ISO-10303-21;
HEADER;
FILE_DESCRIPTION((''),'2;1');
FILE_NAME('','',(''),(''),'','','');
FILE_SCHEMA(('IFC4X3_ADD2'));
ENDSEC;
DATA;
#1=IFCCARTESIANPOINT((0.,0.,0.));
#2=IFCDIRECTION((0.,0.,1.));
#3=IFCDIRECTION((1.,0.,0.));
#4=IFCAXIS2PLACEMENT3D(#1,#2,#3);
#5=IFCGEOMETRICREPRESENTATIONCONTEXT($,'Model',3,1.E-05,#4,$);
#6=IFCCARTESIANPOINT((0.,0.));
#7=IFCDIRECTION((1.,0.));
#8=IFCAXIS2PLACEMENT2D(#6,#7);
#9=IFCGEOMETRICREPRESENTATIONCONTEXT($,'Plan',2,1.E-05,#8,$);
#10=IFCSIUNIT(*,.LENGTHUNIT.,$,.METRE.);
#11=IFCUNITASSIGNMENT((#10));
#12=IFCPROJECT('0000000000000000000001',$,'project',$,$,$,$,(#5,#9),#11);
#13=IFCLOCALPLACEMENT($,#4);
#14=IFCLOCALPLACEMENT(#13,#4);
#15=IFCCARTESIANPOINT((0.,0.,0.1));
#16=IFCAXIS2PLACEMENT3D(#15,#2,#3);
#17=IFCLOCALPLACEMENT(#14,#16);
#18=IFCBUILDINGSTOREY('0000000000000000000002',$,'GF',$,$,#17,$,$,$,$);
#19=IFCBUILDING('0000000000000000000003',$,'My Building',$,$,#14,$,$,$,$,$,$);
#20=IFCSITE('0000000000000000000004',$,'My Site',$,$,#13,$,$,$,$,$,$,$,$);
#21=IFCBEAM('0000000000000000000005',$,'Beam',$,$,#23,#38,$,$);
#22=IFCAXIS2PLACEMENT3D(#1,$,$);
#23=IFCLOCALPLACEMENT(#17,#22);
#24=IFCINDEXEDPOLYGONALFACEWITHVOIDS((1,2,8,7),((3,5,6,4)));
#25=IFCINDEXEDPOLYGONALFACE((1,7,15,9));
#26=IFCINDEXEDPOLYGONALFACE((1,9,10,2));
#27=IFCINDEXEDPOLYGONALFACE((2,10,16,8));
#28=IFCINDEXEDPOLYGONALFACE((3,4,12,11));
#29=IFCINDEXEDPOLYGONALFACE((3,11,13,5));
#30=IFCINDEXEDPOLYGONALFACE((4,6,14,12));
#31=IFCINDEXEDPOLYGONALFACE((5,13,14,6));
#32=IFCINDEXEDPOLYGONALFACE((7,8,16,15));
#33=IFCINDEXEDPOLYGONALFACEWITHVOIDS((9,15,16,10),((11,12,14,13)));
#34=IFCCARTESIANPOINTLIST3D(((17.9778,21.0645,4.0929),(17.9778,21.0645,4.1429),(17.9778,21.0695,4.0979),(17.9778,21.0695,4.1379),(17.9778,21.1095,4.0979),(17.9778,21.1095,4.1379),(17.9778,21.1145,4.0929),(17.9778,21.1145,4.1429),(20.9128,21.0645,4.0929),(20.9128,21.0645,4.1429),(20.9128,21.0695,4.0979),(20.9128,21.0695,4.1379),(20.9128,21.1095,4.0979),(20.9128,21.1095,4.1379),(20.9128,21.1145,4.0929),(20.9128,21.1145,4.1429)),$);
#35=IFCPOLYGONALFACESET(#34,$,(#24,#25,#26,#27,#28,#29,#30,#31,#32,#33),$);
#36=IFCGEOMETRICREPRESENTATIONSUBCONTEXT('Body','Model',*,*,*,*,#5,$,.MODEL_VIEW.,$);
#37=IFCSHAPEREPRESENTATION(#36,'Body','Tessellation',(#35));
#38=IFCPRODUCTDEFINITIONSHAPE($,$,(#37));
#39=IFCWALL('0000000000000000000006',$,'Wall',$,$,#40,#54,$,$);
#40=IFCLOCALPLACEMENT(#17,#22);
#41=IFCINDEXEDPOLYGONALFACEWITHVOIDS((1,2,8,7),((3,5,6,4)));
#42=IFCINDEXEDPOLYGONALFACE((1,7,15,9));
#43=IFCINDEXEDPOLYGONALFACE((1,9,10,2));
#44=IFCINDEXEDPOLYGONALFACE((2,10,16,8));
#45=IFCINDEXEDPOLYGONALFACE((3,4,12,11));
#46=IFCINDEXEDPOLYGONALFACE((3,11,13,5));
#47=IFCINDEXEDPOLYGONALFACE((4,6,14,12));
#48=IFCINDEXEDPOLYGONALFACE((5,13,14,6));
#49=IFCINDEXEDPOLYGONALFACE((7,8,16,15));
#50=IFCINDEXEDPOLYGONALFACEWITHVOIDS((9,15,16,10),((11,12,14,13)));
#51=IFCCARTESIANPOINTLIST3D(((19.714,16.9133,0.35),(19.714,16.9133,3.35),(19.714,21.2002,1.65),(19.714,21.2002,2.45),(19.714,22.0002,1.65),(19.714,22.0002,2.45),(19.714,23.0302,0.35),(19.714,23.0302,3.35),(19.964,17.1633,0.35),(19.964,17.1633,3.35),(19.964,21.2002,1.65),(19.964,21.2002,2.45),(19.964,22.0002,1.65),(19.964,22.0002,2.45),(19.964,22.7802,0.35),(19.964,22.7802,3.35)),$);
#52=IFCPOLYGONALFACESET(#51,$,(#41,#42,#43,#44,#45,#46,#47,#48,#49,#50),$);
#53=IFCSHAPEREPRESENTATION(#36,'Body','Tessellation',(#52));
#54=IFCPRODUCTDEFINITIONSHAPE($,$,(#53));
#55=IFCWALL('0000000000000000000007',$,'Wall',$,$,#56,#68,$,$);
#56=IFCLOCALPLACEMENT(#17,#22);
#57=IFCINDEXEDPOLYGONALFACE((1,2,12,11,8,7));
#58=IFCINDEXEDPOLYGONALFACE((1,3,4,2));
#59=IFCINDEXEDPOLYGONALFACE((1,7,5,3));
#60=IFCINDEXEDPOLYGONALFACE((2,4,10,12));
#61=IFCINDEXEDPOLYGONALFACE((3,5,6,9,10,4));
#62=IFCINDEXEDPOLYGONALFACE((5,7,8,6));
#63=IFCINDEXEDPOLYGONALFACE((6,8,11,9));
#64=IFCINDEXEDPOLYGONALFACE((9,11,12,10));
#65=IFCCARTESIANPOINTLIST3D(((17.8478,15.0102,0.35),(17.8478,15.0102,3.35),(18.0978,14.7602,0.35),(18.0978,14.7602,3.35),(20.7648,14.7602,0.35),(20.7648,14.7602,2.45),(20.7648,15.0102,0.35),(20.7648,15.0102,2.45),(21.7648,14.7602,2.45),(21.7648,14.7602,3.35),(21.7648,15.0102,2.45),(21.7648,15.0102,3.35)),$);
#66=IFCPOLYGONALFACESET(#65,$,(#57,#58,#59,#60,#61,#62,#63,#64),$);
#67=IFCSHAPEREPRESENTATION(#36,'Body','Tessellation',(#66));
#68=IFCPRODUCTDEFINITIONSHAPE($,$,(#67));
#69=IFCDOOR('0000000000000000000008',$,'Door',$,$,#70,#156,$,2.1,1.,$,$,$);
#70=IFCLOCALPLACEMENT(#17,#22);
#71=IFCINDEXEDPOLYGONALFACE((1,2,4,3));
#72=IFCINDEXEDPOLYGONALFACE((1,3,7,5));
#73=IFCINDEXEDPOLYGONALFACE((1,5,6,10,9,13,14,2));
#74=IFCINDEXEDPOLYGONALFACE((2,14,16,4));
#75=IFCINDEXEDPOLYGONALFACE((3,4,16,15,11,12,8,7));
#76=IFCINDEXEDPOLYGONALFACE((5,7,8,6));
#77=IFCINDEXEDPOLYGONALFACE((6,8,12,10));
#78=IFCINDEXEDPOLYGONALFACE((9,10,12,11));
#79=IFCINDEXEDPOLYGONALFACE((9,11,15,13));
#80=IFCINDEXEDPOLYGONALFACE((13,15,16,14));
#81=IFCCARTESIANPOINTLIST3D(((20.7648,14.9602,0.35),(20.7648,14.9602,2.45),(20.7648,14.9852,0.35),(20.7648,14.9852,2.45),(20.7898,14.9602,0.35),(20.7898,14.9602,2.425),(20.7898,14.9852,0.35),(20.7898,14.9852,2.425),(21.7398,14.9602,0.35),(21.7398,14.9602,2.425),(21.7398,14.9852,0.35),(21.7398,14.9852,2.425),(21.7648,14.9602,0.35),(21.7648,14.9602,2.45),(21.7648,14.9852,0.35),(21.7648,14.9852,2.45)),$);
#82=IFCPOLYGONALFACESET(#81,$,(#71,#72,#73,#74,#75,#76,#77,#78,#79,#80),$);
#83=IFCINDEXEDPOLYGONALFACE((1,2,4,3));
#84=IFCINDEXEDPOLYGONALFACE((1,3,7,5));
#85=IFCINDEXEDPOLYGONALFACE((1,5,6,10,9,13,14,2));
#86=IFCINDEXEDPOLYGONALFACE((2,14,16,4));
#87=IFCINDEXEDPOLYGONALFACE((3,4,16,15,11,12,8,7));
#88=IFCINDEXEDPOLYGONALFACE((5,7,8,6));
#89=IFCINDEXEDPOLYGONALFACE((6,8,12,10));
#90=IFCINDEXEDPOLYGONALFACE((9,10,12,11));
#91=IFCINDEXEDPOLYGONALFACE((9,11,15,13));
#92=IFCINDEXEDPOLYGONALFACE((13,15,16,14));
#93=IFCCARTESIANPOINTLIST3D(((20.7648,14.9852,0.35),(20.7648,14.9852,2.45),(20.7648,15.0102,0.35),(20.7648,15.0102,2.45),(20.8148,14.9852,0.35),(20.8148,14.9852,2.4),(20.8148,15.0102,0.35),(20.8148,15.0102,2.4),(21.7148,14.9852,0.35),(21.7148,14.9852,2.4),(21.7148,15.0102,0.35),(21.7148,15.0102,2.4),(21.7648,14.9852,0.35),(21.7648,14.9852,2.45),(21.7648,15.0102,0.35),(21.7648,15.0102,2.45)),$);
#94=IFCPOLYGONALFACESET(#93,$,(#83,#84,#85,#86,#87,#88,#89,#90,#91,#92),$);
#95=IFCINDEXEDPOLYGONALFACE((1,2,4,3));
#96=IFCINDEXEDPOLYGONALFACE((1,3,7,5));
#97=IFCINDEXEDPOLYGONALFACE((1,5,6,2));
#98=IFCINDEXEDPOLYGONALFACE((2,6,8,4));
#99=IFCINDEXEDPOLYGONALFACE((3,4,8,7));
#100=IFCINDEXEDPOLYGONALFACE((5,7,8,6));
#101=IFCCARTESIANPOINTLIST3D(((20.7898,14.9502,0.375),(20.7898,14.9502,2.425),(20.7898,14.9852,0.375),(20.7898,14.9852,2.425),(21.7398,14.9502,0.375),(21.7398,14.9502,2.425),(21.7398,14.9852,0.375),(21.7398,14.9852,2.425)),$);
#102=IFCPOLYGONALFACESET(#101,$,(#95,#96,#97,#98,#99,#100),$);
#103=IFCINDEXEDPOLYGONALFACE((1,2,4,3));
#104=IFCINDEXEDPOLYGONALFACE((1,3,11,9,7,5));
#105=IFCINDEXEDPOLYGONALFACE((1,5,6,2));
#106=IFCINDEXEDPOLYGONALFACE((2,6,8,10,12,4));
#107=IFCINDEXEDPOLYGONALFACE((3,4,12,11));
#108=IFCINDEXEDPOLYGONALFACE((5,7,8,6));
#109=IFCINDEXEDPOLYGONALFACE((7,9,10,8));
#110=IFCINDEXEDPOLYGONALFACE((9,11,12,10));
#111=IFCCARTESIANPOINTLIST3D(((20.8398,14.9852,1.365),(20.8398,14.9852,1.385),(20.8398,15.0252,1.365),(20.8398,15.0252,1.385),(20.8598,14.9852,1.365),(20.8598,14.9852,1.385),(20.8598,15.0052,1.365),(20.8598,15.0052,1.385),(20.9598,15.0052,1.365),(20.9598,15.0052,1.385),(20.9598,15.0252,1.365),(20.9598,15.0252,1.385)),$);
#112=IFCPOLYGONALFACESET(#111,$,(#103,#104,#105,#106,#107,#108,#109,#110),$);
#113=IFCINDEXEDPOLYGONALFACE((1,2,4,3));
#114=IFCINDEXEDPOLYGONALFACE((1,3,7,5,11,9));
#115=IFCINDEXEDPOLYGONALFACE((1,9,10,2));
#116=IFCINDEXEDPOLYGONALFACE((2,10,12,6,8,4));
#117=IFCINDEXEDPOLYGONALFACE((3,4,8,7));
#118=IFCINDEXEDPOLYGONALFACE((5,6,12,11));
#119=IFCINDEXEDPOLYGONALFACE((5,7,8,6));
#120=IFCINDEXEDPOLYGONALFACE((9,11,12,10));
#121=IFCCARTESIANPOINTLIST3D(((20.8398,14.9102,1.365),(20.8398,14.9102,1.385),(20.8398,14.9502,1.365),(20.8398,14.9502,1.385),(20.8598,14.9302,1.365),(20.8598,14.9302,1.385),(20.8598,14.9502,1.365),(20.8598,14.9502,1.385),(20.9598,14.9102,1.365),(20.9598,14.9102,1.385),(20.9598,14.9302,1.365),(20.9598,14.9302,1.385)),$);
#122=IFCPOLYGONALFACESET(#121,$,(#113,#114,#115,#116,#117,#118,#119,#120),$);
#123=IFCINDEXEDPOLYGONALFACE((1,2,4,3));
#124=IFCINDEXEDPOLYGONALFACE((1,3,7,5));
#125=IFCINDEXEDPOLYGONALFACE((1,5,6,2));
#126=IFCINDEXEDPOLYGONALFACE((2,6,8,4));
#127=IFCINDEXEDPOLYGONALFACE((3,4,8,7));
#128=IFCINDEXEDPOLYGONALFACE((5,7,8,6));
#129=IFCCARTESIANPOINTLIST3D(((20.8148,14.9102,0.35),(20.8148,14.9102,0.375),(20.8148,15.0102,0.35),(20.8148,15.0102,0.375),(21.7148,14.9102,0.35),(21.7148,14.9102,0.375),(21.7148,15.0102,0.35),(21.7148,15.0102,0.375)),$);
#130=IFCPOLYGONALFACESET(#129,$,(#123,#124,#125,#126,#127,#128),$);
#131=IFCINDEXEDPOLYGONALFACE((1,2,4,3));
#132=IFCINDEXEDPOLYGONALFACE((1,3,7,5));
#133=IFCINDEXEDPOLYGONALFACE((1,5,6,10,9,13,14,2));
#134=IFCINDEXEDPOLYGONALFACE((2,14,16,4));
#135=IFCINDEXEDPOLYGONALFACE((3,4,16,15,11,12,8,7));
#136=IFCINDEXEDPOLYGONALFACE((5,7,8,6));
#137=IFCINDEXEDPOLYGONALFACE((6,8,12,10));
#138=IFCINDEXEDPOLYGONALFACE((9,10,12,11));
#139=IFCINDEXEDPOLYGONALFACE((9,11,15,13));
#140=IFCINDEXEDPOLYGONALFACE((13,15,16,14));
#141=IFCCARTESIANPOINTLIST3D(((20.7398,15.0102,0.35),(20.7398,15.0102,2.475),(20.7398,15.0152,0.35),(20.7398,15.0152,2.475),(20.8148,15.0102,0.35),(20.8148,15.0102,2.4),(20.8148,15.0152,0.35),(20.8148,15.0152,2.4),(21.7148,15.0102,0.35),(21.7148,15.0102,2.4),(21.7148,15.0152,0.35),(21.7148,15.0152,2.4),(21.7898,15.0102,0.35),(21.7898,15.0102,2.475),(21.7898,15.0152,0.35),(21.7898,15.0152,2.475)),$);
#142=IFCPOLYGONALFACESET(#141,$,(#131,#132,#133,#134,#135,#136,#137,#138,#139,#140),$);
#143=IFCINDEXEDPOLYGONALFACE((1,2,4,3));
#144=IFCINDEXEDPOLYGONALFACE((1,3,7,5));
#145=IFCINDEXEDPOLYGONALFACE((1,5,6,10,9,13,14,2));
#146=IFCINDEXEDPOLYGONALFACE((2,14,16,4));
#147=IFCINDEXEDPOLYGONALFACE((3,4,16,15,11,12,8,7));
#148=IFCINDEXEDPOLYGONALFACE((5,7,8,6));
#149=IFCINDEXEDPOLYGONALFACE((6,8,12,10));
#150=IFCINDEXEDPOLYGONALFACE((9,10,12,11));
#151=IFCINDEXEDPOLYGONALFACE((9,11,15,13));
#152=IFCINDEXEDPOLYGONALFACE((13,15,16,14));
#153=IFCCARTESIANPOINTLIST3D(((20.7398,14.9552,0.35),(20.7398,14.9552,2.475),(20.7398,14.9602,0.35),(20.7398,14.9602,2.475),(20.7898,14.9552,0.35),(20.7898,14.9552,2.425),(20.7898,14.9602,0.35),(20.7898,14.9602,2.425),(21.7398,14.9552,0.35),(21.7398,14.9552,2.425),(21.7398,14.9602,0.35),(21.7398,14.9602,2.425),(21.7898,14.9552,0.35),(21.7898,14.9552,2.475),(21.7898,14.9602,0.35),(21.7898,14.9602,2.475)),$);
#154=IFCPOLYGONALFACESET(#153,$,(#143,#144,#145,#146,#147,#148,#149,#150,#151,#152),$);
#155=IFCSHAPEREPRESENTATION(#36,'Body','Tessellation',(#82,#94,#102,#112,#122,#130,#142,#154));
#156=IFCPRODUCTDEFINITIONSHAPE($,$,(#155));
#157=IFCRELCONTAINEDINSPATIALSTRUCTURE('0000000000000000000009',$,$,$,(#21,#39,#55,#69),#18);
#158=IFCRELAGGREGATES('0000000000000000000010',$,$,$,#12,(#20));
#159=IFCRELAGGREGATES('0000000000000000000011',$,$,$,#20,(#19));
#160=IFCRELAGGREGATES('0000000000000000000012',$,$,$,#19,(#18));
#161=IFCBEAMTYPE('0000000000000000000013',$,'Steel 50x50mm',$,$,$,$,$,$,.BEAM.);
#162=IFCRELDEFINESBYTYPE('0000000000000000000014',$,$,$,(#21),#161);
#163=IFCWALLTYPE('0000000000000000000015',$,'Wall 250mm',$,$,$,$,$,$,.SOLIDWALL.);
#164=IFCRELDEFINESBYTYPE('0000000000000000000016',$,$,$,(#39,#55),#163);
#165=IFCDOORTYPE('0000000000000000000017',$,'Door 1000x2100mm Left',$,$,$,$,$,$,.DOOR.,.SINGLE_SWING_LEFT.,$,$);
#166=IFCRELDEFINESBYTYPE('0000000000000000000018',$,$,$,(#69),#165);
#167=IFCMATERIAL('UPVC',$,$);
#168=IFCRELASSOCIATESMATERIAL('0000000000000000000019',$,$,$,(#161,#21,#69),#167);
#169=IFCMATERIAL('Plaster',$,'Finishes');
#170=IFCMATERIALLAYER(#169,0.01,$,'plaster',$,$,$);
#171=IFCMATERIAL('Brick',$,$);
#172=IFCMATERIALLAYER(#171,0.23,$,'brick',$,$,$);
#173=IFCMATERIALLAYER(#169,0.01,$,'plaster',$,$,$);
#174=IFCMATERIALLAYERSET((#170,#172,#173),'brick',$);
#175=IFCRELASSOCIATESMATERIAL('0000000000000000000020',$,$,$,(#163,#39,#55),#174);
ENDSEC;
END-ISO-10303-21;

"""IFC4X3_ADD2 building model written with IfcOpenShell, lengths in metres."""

from ifc_helpers import new_model, entity, si_unit, frame, origin_with_axes, origin_2d_with_axis, place, context, subcontext, project, spatial, line, indexed_curve, hollow_rectangle, outline, extrude, shape, source, transform, mapped, material, layer, layer_set, layer_usage, material_profile, profile_set, profile_usage, type_object, type_shapes, element, fill, save


model = new_model("IFC4X3_ADD2")

# Units and contexts
model_context = context("Model", 3, precision=1e-05, world=origin_with_axes())
plan_context = context("Plan", 2, precision=1e-05, world=origin_2d_with_axis())
body_context_1 = subcontext(model_context, "Body", "Model", "MODEL_VIEW")
body_context_2 = subcontext(plan_context, "Body", "Plan", "PLAN_VIEW")
ifc_project = project(units=[si_unit("LENGTHUNIT", "METRE")], contexts=[model_context, plan_context])

# Site, building, storey
site_placement = place(None, origin_with_axes())
site = spatial("IfcSite", under=ifc_project, at=site_placement, Name="My Site")
building_placement = place(site_placement, origin_with_axes())
building = spatial("IfcBuilding", under=site, at=building_placement, Name="My Building")
storey_placement = place(building_placement, frame((0.0, 0.0, 0.1), z_axis=(0.0, 0.0, 1.0), x_axis=(1.0, 0.0, 0.0)))
storey = spatial("IfcBuildingStorey", under=building, at=storey_placement, Name="GF")

# Beam
ifc_material_1 = material(Name="UPVC")
ifc_material_profile = material_profile(ifc_material_1, hollow_rectangle(XDim=0.05, YDim=0.05, WallThickness=0.005))
ifc_profile_set = profile_set([ifc_material_profile])
ifc_profile_usage = profile_usage(ifc_profile_set)
beam_type = type_object("IfcBeamType", Name="Steel 50x50mm", PredefinedType="BEAM", material=ifc_profile_set)
beam_placement = place(storey_placement, frame((17.9778, 21.0895, 4.1179), z_axis=(1.0, 0.0, 0.0), x_axis=(0.0, 1.0, 0.0)))
element("IfcBeam", 1, at=beam_placement, inside=storey, type_object=beam_type, material=ifc_profile_usage, Name="Beam", context=body_context_1, shape_type="SweptSolid", body=[
    extrude(hollow_rectangle(XDim=0.05, YDim=0.05, WallThickness=0.005), origin_with_axes(), (0.0, 0.0, 1.0), 2.9351),
])

# Wall, opening
ifc_material_2 = material(Name="Plaster", Category="Finishes")
ifc_layer_1 = layer(ifc_material_2, 0.01, Name="plaster")
ifc_material_3 = material(Name="Brick")
ifc_layer_2 = layer(ifc_material_3, 0.23, Name="brick")
ifc_layer_3 = layer(ifc_material_2, 0.01, Name="plaster")
ifc_layer_set_1 = layer_set([ifc_layer_1, ifc_layer_2, ifc_layer_3], Name="brick")
ifc_layer_usage_1 = layer_usage(ifc_layer_set_1, "AXIS2", "NEGATIVE", 0.0)
wall_type_1 = type_object("IfcWallType", Name="Wall 250mm", PredefinedType="SOLIDWALL", material=ifc_layer_set_1)
wall_1_placement = place(storey_placement, frame((19.714, 17.1633, 0.35), z_axis=(0.0, 0.0, 1.0), x_axis=(0.000001, 1.0, 0.0)))
wall_1 = element("IfcWall", 2, at=wall_1_placement, inside=storey, type_object=wall_type_1, material=ifc_layer_usage_1, Name="Wall", context=body_context_1, shape_type="SweptSolid", body=[
    extrude(outline(indexed_curve([(0.0, -0.25), (-0.25, 0.0), (5.8669, 0.0), (5.6169, -0.25)], segments=[line(1, 2, 3, 4, 1)])), origin_with_axes(), (0.0, 0.0, 1.0), 3.0),
])
shared_shape_1 = source(origin_with_axes(), body_context_1, "Body", "SweptSolid", [
    extrude(outline(indexed_curve([(0.0, 0.0), (0.8, 0.0), (0.8, 0.8), (0.0, 0.8)], segments=[line(1, 2, 3, 4, 1)])), frame((-0.4, -0.6, 0.0), z_axis=(0.0, -1.0, 0.0), x_axis=(1.0, 0.0, 0.0)), (0.0, 0.0, -1.0), 1.2),
])
opening_1_placement = place(wall_1_placement, frame((4.4369, 0.0, 1.3), z_axis=(0.0, 0.0, 1.0), x_axis=(1.0, 0.0, 0.0)))
element("IfcOpeningElement", 3, at=opening_1_placement, cuts=wall_1, PredefinedType="OPENING", context=body_context_1, shape_type="MappedRepresentation", body=[
    mapped(shared_shape_1, transform((0.0, 0.0, 0.0), x_axis=(1.0, 0.0, 0.0), y_axis=(0.0, 1.0, 0.0), z_axis=(0.0, 0.0, 1.0), scale=1.0)),
])

# Wall, opening, door
ifc_layer_usage_2 = layer_usage(ifc_layer_set_1, "AXIS2", "POSITIVE", 0.0)
wall_2_placement = place(storey_placement, frame((21.7648, 15.0102, 0.35), z_axis=(0.0, 0.0, 1.0), x_axis=(-1.0, 0.0, 0.0)))
wall_2 = element("IfcWall", 4, at=wall_2_placement, inside=storey, type_object=wall_type_1, material=ifc_layer_usage_2, Name="Wall", context=body_context_1, shape_type="SweptSolid", body=[
    extrude(outline(indexed_curve([(0.0, 0.0), (0.0, 0.25), (3.667, 0.25), (3.917, 0.0)], segments=[line(1, 2, 3, 4, 1)])), origin_with_axes(), (0.0, 0.0, 1.0), 3.0),
])
shared_shape_2 = source(origin_with_axes(), body_context_1, "Body", "SweptSolid", [
    extrude(outline(indexed_curve([(0.0, 0.0), (1.0, 0.0), (1.0, 2.1), (0.0, 2.1)], segments=[line(1, 2, 3, 4, 1)])), frame((0.0, -0.6, 0.0), z_axis=(0.0, -1.0, 0.0), x_axis=(1.0, 0.0, 0.0)), (0.0, 0.0, -1.0), 1.2),
])
opening_2_placement = place(wall_2_placement, frame((0.0, 0.0, 0.0), z_axis=(0.0, 0.0, 1.0), x_axis=(1.0, 0.0, 0.0)))
opening_2 = element("IfcOpeningElement", 5, at=opening_2_placement, cuts=wall_2, PredefinedType="OPENING", context=body_context_1, shape_type="MappedRepresentation", body=[
    mapped(shared_shape_2, transform((0.0, 0.0, 0.0), x_axis=(1.0, 0.0, 0.0), y_axis=(0.0, 1.0, 0.0), z_axis=(0.0, 0.0, 1.0), scale=1.0)),
])
door_type_1 = type_object("IfcDoorType", Name="Door 1000x2100mm Left", OperationType="SINGLE_SWING_LEFT", PredefinedType="DOOR")
shared_shape_3 = source(origin_with_axes(), body_context_1, "Body", "SweptSolid", [
    extrude(outline(indexed_curve([(0.0, 0.0), (0.0, 2.1), (1.0, 2.1), (1.0, 0.0), (0.975, 0.0), (0.975, 2.075), (0.025, 2.075), (0.025, 0.0)], segments=[line(1, 2, 3, 4, 5, 6, 7, 8, 1)])), frame((0.0, 0.025, 0.0), z_axis=(0.0, -1.0, 0.0), x_axis=(1.0, 0.0, 0.0)), (0.0, 0.0, -1.0), 0.025),
    extrude(outline(indexed_curve([(0.0, 0.0), (0.0, 2.1), (1.0, 2.1), (1.0, 0.0), (0.95, 0.0), (0.95, 2.05), (0.05, 2.05), (0.05, 0.0)], segments=[line(1, 2, 3, 4, 5, 6, 7, 8, 1)])), frame((0.0, 0.0, 0.0), z_axis=(0.0, -1.0, 0.0), x_axis=(1.0, 0.0, 0.0)), (0.0, 0.0, -1.0), 0.025),
    extrude(outline(indexed_curve([(0.0, 0.0), (0.95, 0.0), (0.95, 0.035), (0.0, 0.035)], segments=[line(1, 2, 3, 4, 1)])), frame((0.025, 0.025, 0.025), z_axis=(0.0, 0.0, 1.0), x_axis=(1.0, 0.0, 0.0)), (0.0, 0.0, 1.0), 2.05),
    extrude(outline(indexed_curve([(0.0, 0.0), (0.0, -0.04), (-0.12, -0.04), (-0.12, -0.02), (-0.02, -0.02), (-0.02, 0.0)], segments=[line(1, 2, 3, 4, 5, 6, 1)])), frame((0.925, 0.025, 1.015), z_axis=(0.0, 0.0, 1.0), x_axis=(1.0, 0.0, 0.0)), (0.0, 0.0, 1.0), 0.02),
    extrude(outline(indexed_curve([(0.0, 0.0), (0.0, 0.04), (-0.12, 0.04), (-0.12, 0.02), (-0.02, 0.02), (-0.02, 0.0)], segments=[line(1, 2, 3, 4, 5, 6, 1)])), frame((0.925, 0.06, 1.015), z_axis=(0.0, 0.0, 1.0), x_axis=(1.0, 0.0, 0.0)), (0.0, 0.0, 1.0), 0.02),
    extrude(outline(indexed_curve([(0.0, 0.0), (0.9, 0.0), (0.9, 0.1), (0.0, 0.1)], segments=[line(1, 2, 3, 4, 1)])), frame((0.05, 0.0, 0.0), z_axis=(0.0, 0.0, 1.0), x_axis=(1.0, 0.0, 0.0)), (0.0, 0.0, 1.0), 0.025),
    extrude(outline(indexed_curve([(0.0, 0.0), (0.0, 2.125), (1.05, 2.125), (1.05, 0.0), (0.975, 0.0), (0.975, 2.05), (0.075, 2.05), (0.075, 0.0)], segments=[line(1, 2, 3, 4, 5, 6, 7, 8, 1)])), frame((-0.025, -0.005, 0.0), z_axis=(0.0, -1.0, 0.0), x_axis=(1.0, 0.0, 0.0)), (0.0, 0.0, -1.0), 0.005),
    extrude(outline(indexed_curve([(0.0, 0.0), (0.0, 2.125), (1.05, 2.125), (1.05, 0.0), (1.0, 0.0), (1.0, 2.075), (0.05, 2.075), (0.05, 0.0)], segments=[line(1, 2, 3, 4, 5, 6, 7, 8, 1)])), frame((-0.025, 0.05, 0.0), z_axis=(0.0, -1.0, 0.0), x_axis=(1.0, 0.0, 0.0)), (0.0, 0.0, -1.0), 0.005),
])
shared_shape_4 = source(origin_with_axes(), body_context_2, "Body", "Curve2D", [
    entity("IfcIndexedPolyCurve", entity("IfcCartesianPointList2D", [[0.0, 0.0], [0.0, 0.05], [0.025, 0.05], [0.025, 0.025], [0.05, 0.025], [0.05, 0.0]]), [entity("IfcLineIndex", [1, 2, 3, 4, 5, 6, 1])]),
    entity("IfcIndexedPolyCurve", entity("IfcCartesianPointList2D", [[1.0, 0.0], [1.0, 0.05], [0.975, 0.05], [0.975, 0.025], [0.95, 0.025], [0.95, 0.0]]), [entity("IfcLineIndex", [1, 2, 3, 4, 5, 6, 1])]),
    entity("IfcTrimmedCurve", entity("IfcEllipse", entity("IfcAxis2Placement2D", entity("IfcCartesianPoint", [0.06, 0.05]), entity("IfcDirection", [1.0, 0.0])), 0.915, 0.95), [entity("IfcCartesianPoint", [0.975, 0.05])], [entity("IfcCartesianPoint", [0.06, 1.0])], True, "CARTESIAN"),
    entity("IfcIndexedPolyCurve", entity("IfcCartesianPointList2D", [[0.025, 0.05], [0.06, 0.05], [0.06, 1.0], [0.025, 1.0]]), [entity("IfcLineIndex", [1, 2, 3, 4, 1])]),
])
type_shapes(door_type_1, [shared_shape_3, shared_shape_4])
door_1_placement = place(opening_2_placement, frame((0.0, 0.0, 0.0), z_axis=(0.0, 0.0, 1.0), x_axis=(1.0, 0.0, 0.0)))
door_1 = element("IfcDoor", 6, at=door_1_placement, inside=storey, type_object=door_type_1, material=ifc_material_1, Name="Door", OverallHeight=2.1, OverallWidth=1.0, shapes=[
    shape(body_context_1, "Body", "MappedRepresentation", [mapped(shared_shape_3, transform((0.0, 0.0, 0.0), x_axis=(1.0, 0.0, 0.0), y_axis=(0.0, 1.0, 0.0), z_axis=(0.0, 0.0, 1.0), scale=1.0))]),
    shape(body_context_2, "Body", "MappedRepresentation", [mapped(shared_shape_4, transform((0.0, 0.0, 0.0), x_axis=(1.0, 0.0, 0.0), y_axis=(0.0, 1.0, 0.0), z_axis=(0.0, 0.0, 1.0), scale=1.0))]),
])
fill(opening_2, door_1)

save(model, "model.ifc")
